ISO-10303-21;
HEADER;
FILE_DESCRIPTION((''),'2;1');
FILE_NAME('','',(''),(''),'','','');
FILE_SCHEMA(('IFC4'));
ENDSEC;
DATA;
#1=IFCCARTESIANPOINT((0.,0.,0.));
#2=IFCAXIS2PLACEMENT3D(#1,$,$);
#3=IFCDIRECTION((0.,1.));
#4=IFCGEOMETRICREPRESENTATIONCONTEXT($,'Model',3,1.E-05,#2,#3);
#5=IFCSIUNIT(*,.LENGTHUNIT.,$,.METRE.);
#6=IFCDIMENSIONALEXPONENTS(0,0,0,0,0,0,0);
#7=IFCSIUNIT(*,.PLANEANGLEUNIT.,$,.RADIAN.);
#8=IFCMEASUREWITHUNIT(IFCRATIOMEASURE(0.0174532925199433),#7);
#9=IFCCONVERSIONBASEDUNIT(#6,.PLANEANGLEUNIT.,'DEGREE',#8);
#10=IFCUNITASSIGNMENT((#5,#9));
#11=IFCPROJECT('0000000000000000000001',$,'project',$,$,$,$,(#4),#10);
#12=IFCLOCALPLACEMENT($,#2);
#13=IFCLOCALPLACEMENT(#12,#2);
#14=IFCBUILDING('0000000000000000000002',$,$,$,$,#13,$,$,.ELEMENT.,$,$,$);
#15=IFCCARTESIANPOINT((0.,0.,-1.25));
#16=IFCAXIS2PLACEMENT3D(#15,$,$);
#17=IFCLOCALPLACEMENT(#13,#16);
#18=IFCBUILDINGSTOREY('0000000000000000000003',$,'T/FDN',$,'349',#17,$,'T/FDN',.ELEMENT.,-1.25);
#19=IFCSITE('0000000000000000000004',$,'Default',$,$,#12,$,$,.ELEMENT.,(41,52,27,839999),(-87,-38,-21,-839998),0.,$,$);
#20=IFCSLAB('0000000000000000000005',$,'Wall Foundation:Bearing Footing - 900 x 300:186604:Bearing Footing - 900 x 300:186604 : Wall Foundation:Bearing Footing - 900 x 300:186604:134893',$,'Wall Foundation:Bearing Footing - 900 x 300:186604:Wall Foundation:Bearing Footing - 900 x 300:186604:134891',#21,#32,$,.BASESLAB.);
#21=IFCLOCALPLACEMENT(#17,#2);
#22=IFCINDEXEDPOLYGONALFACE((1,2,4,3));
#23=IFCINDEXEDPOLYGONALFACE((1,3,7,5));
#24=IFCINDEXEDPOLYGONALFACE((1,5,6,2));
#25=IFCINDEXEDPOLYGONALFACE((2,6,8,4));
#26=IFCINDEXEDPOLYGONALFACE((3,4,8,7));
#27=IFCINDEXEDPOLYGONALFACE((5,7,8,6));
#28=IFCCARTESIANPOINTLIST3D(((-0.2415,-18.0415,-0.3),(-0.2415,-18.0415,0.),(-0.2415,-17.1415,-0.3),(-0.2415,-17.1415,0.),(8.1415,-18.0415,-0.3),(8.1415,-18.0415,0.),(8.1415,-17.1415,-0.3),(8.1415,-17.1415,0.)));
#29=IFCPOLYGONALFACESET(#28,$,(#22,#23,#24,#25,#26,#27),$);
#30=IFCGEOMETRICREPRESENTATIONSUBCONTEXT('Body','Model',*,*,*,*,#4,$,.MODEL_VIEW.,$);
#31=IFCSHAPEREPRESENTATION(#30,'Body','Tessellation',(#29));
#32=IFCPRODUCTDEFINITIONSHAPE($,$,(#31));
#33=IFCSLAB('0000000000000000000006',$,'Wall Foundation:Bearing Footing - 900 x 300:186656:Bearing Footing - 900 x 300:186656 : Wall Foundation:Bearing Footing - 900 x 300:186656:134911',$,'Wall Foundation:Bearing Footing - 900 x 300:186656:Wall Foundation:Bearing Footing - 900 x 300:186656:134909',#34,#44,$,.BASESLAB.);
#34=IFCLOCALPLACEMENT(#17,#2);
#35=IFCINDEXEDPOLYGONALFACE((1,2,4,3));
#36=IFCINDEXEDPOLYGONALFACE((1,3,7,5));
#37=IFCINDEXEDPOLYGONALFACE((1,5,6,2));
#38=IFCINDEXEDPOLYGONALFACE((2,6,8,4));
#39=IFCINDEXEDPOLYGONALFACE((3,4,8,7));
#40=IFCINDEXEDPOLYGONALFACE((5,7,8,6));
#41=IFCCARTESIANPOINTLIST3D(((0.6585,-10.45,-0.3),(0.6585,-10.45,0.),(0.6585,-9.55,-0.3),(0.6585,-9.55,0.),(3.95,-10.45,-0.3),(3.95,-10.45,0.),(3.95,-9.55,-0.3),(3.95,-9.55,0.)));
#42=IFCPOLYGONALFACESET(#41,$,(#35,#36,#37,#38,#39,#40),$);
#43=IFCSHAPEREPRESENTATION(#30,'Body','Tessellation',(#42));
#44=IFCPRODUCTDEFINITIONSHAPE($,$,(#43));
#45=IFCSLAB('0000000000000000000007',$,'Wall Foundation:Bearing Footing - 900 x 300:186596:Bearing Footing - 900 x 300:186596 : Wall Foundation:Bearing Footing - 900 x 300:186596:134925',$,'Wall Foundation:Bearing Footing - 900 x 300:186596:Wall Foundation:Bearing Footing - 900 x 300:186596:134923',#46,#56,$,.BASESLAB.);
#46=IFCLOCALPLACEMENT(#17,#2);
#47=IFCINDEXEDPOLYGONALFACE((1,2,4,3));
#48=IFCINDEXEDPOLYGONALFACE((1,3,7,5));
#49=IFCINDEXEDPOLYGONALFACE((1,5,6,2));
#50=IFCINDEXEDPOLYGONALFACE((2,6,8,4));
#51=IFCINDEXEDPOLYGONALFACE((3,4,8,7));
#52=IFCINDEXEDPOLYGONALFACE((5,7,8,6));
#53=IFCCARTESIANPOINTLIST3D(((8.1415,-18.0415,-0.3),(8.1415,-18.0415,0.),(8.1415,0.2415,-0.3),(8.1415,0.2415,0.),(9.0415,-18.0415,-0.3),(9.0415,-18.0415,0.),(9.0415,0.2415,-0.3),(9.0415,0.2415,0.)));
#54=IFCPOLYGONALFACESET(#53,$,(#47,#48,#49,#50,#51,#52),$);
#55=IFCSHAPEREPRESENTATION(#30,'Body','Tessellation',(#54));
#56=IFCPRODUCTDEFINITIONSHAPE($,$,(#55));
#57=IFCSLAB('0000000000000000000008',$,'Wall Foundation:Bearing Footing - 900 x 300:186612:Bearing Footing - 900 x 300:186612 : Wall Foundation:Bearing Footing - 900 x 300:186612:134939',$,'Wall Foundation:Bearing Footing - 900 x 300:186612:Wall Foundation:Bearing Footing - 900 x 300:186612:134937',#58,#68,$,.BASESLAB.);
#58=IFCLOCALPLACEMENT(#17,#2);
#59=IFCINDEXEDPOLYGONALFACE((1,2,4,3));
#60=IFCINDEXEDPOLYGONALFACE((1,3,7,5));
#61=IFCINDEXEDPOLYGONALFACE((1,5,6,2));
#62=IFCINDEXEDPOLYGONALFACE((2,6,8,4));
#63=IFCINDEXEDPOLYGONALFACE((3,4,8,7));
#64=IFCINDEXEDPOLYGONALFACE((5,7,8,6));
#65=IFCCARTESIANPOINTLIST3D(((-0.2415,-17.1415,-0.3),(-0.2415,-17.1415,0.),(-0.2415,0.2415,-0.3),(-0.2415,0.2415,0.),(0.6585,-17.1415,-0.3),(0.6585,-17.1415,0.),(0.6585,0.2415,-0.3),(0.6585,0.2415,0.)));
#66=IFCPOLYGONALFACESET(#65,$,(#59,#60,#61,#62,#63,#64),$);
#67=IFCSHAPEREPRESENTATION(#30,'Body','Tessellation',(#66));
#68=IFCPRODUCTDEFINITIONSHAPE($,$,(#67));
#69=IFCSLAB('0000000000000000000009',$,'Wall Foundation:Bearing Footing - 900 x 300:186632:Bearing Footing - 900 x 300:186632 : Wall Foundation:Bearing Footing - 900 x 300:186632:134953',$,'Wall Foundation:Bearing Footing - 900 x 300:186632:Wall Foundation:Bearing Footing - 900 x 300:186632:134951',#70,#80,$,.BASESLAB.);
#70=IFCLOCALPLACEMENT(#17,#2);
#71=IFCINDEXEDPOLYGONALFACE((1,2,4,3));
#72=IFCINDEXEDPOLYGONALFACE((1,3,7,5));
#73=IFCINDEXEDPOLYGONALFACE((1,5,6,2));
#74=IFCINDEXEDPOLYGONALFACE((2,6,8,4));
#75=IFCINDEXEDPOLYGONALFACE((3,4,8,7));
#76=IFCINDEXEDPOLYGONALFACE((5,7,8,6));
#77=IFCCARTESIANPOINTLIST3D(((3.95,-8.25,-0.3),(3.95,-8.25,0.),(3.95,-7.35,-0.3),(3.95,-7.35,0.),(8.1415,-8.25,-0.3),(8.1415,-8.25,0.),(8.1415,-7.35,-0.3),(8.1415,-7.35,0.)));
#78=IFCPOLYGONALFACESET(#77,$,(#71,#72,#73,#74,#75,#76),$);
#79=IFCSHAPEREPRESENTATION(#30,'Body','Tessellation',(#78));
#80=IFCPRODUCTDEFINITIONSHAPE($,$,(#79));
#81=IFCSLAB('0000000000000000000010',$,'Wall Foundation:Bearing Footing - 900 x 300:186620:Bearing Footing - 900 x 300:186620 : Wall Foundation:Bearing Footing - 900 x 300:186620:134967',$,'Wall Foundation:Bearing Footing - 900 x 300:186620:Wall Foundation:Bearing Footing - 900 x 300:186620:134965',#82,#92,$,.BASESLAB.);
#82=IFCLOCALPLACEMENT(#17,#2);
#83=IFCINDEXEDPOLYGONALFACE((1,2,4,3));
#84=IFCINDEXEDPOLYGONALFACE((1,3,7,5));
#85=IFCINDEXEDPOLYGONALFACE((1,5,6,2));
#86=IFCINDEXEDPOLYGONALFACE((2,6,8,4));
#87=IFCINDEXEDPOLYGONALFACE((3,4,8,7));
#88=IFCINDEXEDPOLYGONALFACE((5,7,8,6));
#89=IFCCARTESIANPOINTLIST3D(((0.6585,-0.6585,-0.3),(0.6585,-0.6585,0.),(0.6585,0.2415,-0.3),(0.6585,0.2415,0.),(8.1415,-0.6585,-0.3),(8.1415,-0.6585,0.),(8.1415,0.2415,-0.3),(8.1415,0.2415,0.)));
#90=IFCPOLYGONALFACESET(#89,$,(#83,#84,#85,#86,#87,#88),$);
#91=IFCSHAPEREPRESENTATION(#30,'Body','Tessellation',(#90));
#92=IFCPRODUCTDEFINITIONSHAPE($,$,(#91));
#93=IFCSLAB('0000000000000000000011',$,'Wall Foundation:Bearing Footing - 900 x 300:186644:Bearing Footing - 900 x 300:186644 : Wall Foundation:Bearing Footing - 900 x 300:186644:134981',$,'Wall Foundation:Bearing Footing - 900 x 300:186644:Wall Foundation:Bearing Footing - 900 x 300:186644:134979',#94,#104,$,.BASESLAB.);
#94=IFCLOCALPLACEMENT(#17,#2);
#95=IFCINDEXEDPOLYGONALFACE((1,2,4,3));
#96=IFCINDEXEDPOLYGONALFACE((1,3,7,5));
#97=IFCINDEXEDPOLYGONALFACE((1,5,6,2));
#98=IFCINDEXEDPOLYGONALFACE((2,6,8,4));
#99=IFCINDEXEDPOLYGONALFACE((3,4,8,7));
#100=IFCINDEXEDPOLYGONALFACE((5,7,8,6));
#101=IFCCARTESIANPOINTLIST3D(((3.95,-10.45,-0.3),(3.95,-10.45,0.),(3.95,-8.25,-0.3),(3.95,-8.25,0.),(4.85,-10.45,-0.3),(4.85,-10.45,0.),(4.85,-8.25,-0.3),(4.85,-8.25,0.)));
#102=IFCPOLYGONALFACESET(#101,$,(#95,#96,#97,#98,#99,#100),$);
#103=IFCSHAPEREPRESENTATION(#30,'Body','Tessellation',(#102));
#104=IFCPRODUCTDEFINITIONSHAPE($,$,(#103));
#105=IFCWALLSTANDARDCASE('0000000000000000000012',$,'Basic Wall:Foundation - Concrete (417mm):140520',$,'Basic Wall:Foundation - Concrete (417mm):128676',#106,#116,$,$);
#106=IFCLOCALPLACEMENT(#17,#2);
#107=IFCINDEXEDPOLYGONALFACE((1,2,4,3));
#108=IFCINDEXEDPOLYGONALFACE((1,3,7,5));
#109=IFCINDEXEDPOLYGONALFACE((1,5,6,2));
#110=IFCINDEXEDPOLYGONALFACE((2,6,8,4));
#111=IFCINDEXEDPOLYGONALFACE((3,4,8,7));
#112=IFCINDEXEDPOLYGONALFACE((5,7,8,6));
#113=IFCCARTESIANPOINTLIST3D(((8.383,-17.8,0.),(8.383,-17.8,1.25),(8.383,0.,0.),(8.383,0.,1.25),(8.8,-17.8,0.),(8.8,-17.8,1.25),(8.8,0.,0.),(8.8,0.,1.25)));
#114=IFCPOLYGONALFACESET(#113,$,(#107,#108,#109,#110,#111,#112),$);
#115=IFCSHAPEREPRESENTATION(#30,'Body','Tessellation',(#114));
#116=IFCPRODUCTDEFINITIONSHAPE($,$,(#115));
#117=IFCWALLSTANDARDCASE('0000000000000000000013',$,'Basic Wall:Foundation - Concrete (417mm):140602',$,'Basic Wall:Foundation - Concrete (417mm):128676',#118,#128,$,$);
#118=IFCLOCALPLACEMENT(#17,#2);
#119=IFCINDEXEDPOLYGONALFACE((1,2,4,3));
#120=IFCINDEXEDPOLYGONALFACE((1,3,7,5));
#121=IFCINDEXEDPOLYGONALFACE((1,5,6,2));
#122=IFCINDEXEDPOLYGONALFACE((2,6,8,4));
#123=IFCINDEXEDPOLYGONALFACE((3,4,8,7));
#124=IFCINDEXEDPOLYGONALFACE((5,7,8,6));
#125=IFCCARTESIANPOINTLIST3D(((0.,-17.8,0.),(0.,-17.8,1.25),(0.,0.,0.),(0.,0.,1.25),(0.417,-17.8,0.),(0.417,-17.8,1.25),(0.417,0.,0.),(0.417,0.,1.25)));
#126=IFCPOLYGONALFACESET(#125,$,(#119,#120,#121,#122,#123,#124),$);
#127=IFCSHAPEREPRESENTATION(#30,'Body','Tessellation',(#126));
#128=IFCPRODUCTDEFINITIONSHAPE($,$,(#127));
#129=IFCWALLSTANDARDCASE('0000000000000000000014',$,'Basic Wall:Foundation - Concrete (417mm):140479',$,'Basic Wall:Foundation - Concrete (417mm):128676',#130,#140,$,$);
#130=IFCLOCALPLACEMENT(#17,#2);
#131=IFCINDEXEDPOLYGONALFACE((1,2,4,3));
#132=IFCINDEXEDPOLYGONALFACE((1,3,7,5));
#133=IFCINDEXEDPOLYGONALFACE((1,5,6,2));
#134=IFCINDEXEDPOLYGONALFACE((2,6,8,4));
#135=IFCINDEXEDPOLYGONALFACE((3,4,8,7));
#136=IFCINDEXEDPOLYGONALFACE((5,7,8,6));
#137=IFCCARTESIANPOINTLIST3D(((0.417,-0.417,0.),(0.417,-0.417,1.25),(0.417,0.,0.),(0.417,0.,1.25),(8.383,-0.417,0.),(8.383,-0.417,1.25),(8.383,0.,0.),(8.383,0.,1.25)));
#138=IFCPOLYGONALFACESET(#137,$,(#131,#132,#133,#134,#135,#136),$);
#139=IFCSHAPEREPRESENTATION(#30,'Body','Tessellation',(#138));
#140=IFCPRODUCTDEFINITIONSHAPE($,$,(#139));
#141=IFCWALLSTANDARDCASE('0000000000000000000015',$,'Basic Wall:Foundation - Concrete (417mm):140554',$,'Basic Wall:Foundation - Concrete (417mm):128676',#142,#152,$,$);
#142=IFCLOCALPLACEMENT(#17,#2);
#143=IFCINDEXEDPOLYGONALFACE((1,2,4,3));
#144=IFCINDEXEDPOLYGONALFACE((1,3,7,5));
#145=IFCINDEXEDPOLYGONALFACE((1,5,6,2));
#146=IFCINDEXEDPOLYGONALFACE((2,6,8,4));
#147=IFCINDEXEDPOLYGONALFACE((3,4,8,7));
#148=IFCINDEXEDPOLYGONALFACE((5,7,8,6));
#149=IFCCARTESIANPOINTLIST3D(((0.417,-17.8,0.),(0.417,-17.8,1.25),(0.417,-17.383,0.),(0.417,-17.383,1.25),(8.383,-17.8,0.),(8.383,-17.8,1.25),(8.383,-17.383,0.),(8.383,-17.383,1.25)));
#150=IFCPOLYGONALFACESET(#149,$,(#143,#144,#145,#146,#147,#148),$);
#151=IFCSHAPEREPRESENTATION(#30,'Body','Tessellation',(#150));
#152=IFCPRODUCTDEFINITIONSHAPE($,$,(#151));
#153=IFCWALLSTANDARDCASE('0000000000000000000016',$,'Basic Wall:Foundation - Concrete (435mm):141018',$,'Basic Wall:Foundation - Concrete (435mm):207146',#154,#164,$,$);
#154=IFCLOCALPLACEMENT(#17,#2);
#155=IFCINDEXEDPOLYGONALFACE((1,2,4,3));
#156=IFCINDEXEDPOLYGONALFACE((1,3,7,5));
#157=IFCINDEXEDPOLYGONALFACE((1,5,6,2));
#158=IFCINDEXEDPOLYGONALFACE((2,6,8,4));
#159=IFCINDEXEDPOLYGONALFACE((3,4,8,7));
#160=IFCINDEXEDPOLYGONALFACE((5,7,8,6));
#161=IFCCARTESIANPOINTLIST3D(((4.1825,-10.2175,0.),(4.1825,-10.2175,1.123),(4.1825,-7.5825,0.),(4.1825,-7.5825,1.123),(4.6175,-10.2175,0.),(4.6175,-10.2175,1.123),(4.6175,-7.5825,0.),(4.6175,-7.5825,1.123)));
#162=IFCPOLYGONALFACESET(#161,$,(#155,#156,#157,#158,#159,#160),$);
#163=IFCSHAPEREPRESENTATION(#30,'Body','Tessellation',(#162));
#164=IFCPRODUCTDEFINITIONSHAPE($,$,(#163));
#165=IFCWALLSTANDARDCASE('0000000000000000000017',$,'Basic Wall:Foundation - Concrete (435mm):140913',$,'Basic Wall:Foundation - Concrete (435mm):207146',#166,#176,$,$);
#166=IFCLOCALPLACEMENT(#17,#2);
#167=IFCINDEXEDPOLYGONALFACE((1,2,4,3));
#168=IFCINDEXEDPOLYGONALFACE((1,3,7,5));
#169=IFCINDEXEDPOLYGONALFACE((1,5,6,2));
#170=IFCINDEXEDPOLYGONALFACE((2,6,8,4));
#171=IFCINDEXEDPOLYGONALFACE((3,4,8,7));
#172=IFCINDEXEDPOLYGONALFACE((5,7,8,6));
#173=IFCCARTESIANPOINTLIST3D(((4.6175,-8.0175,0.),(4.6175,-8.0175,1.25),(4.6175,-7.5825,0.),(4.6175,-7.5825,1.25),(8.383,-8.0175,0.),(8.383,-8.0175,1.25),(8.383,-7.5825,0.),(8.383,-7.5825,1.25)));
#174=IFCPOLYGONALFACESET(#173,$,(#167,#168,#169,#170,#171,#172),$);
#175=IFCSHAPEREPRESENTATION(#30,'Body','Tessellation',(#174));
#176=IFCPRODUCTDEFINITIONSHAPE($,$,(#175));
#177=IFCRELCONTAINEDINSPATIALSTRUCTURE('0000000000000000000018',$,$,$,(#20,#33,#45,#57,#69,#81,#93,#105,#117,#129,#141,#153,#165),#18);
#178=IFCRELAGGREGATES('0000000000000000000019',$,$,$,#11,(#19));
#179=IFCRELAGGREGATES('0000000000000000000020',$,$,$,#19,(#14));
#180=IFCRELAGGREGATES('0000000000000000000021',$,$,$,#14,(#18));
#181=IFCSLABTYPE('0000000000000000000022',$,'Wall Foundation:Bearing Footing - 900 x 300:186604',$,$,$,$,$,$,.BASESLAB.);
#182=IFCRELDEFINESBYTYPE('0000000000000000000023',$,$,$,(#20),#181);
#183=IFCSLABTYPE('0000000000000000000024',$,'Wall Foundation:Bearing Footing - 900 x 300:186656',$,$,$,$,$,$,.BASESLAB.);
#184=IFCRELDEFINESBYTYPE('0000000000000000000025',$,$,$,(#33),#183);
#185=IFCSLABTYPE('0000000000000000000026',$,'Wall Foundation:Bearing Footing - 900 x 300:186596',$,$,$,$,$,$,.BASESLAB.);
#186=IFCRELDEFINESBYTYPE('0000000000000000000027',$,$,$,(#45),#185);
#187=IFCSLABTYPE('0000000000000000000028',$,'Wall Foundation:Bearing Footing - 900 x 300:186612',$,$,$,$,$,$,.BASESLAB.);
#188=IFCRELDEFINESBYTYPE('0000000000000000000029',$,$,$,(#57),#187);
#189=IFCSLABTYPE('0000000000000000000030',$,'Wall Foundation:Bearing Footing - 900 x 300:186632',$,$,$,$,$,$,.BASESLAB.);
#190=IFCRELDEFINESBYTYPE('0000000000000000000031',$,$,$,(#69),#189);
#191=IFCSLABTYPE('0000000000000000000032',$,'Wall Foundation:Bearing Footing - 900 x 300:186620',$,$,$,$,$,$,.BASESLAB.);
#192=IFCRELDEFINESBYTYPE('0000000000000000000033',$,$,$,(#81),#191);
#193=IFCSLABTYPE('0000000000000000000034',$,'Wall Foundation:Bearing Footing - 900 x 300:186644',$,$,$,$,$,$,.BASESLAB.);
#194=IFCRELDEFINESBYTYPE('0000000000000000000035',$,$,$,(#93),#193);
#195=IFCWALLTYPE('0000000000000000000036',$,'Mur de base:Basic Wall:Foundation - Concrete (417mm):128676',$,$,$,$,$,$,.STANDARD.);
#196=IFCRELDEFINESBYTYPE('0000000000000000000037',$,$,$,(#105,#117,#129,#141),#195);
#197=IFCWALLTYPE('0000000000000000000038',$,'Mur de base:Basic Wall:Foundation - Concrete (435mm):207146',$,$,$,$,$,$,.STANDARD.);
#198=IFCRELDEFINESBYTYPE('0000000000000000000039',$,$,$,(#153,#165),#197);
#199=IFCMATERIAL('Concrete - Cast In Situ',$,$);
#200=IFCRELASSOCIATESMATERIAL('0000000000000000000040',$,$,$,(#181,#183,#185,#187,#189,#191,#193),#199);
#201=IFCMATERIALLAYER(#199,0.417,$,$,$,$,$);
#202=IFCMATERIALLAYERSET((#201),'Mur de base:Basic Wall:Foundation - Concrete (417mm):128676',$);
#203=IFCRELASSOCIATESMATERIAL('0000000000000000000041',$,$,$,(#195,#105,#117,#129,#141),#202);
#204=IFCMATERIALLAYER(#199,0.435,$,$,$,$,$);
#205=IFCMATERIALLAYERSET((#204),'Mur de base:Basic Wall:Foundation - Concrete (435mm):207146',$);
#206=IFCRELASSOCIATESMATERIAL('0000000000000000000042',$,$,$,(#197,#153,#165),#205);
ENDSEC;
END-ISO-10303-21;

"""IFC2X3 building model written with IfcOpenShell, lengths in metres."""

from ifc_helpers import new_model, entity, si_unit, converted_unit, direction, frame, frame_2d, origin, origin_2d_with_axis, place, context, subcontext, project, spatial, rectangle, extrude, material, layer, layer_set, layer_usage, type_object, element, save


model = new_model("IFC2X3")

# Units and contexts
model_context = context("Model", 3, precision=1e-05, world=origin(), true_north=direction((0.0, 1.0)))
body_context = subcontext(model_context, "Body", "Model", "MODEL_VIEW")
ifc_project = project(units=[si_unit("LENGTHUNIT", "METRE"), converted_unit("PLANEANGLEUNIT", "DEGREE", entity("IfcRatioMeasure", 0.0174532925199433), si_unit("PLANEANGLEUNIT", "RADIAN"), dimensions=[0, 0, 0, 0, 0, 0, 0])], contexts=[model_context])

# Site, building, storey
site_placement = place(None, origin())
site = spatial("IfcSite", under=ifc_project, at=site_placement, Name="Default", CompositionType="ELEMENT", RefLatitude=(41, 52, 27, 839999), RefLongitude=(-87, -38, -21, -839998), RefElevation=0.0)
building_placement = place(site_placement, origin())
building = spatial("IfcBuilding", under=site, at=building_placement, CompositionType="ELEMENT")
storey_placement = place(building_placement, frame((0.0, 0.0, -1.25)))
storey = spatial("IfcBuildingStorey", under=building, at=storey_placement, Name="T/FDN", ObjectType="349", LongName="T/FDN", CompositionType="ELEMENT", Elevation=-1.25)

# Slabs
ifc_material = material(Name="Concrete - Cast In Situ")
slab_type_1 = type_object("IfcSlabType", Name="Wall Foundation:Bearing Footing - 900 x 300:186604", PredefinedType="BASESLAB", material=ifc_material)
slab_1_placement = place(storey_placement, origin())
element("IfcSlab", 1, at=slab_1_placement, inside=storey, type_object=slab_type_1, Name="Wall Foundation:Bearing Footing - 900 x 300:186604:Bearing Footing - 900 x 300:186604 : Wall Foundation:Bearing Footing - 900 x 300:186604:134893", ObjectType="Wall Foundation:Bearing Footing - 900 x 300:186604:Wall Foundation:Bearing Footing - 900 x 300:186604:134891", PredefinedType="BASESLAB", context=body_context, shape_type="SweptSolid", body=[
    extrude(rectangle(XDim=0.9, YDim=8.383, at=origin_2d_with_axis()), frame((3.95, -17.5915, -0.3), z_axis=(0.0, 0.0, 1.0), x_axis=(0.0, 1.0, 0.0)), (0.0, 0.0, 1.0), 0.3),
])
slab_type_2 = type_object("IfcSlabType", Name="Wall Foundation:Bearing Footing - 900 x 300:186656", PredefinedType="BASESLAB", material=ifc_material)
slab_2_placement = place(storey_placement, origin())
element("IfcSlab", 2, at=slab_2_placement, inside=storey, type_object=slab_type_2, Name="Wall Foundation:Bearing Footing - 900 x 300:186656:Bearing Footing - 900 x 300:186656 : Wall Foundation:Bearing Footing - 900 x 300:186656:134911", ObjectType="Wall Foundation:Bearing Footing - 900 x 300:186656:Wall Foundation:Bearing Footing - 900 x 300:186656:134909", PredefinedType="BASESLAB", context=body_context, shape_type="SweptSolid", body=[
    extrude(rectangle(XDim=0.9, YDim=3.2915, at=frame_2d((0.0, 0.0), x_axis=(1.0, 0.0))), frame((2.3043, -10.0, -0.3), z_axis=(0.0, 0.0, 1.0), x_axis=(0.0, 1.0, 0.0)), (0.0, 0.0, 1.0), 0.3),
])
slab_type_3 = type_object("IfcSlabType", Name="Wall Foundation:Bearing Footing - 900 x 300:186596", PredefinedType="BASESLAB", material=ifc_material)
slab_3_placement = place(storey_placement, origin())
element("IfcSlab", 3, at=slab_3_placement, inside=storey, type_object=slab_type_3, Name="Wall Foundation:Bearing Footing - 900 x 300:186596:Bearing Footing - 900 x 300:186596 : Wall Foundation:Bearing Footing - 900 x 300:186596:134925", ObjectType="Wall Foundation:Bearing Footing - 900 x 300:186596:Wall Foundation:Bearing Footing - 900 x 300:186596:134923", PredefinedType="BASESLAB", context=body_context, shape_type="SweptSolid", body=[
    extrude(rectangle(XDim=0.9, YDim=18.283, at=frame_2d((0.0, 0.0), x_axis=(1.0, 0.0))), frame((8.5915, -8.9, -0.3)), (0.0, 0.0, 1.0), 0.3),
])
slab_type_4 = type_object("IfcSlabType", Name="Wall Foundation:Bearing Footing - 900 x 300:186612", PredefinedType="BASESLAB", material=ifc_material)
slab_4_placement = place(storey_placement, origin())
element("IfcSlab", 4, at=slab_4_placement, inside=storey, type_object=slab_type_4, Name="Wall Foundation:Bearing Footing - 900 x 300:186612:Bearing Footing - 900 x 300:186612 : Wall Foundation:Bearing Footing - 900 x 300:186612:134939", ObjectType="Wall Foundation:Bearing Footing - 900 x 300:186612:Wall Foundation:Bearing Footing - 900 x 300:186612:134937", PredefinedType="BASESLAB", context=body_context, shape_type="SweptSolid", body=[
    extrude(rectangle(XDim=0.9, YDim=17.383, at=origin_2d_with_axis()), frame((0.2085, -8.45, -0.3)), (0.0, 0.0, 1.0), 0.3),
])
slab_type_5 = type_object("IfcSlabType", Name="Wall Foundation:Bearing Footing - 900 x 300:186632", PredefinedType="BASESLAB", material=ifc_material)
slab_5_placement = place(storey_placement, origin())
element("IfcSlab", 5, at=slab_5_placement, inside=storey, type_object=slab_type_5, Name="Wall Foundation:Bearing Footing - 900 x 300:186632:Bearing Footing - 900 x 300:186632 : Wall Foundation:Bearing Footing - 900 x 300:186632:134953", ObjectType="Wall Foundation:Bearing Footing - 900 x 300:186632:Wall Foundation:Bearing Footing - 900 x 300:186632:134951", PredefinedType="BASESLAB", context=body_context, shape_type="SweptSolid", body=[
    extrude(rectangle(XDim=0.9, YDim=4.1915, at=frame_2d((0.0, 0.0), x_axis=(1.0, 0.0))), frame((6.0457, -7.8, -0.3), z_axis=(0.0, 0.0, 1.0), x_axis=(0.0, -1.0, 0.0)), (0.0, 0.0, 1.0), 0.3),
])
slab_type_6 = type_object("IfcSlabType", Name="Wall Foundation:Bearing Footing - 900 x 300:186620", PredefinedType="BASESLAB", material=ifc_material)
slab_6_placement = place(storey_placement, origin())
element("IfcSlab", 6, at=slab_6_placement, inside=storey, type_object=slab_type_6, Name="Wall Foundation:Bearing Footing - 900 x 300:186620:Bearing Footing - 900 x 300:186620 : Wall Foundation:Bearing Footing - 900 x 300:186620:134967", ObjectType="Wall Foundation:Bearing Footing - 900 x 300:186620:Wall Foundation:Bearing Footing - 900 x 300:186620:134965", PredefinedType="BASESLAB", context=body_context, shape_type="SweptSolid", body=[
    extrude(rectangle(XDim=0.9, YDim=7.483, at=frame_2d((0.0, 0.0), x_axis=(1.0, 0.0))), frame((4.4, -0.2085, -0.3), z_axis=(0.0, 0.0, 1.0), x_axis=(0.0, -1.0, 0.0)), (0.0, 0.0, 1.0), 0.3),
])
slab_type_7 = type_object("IfcSlabType", Name="Wall Foundation:Bearing Footing - 900 x 300:186644", PredefinedType="BASESLAB", material=ifc_material)
slab_7_placement = place(storey_placement, origin())
element("IfcSlab", 7, at=slab_7_placement, inside=storey, type_object=slab_type_7, Name="Wall Foundation:Bearing Footing - 900 x 300:186644:Bearing Footing - 900 x 300:186644 : Wall Foundation:Bearing Footing - 900 x 300:186644:134981", ObjectType="Wall Foundation:Bearing Footing - 900 x 300:186644:Wall Foundation:Bearing Footing - 900 x 300:186644:134979", PredefinedType="BASESLAB", context=body_context, shape_type="SweptSolid", body=[
    extrude(rectangle(XDim=0.9, YDim=2.2, at=frame_2d((0.0, 0.0), x_axis=(1.0, 0.0))), frame((4.4, -9.35, -0.3), z_axis=(0.0, 0.0, 1.0), x_axis=(-1.0, 0.0, 0.0)), (0.0, 0.0, 1.0), 0.3),
])

# Walls
ifc_layer_1 = layer(ifc_material, 0.417)
ifc_layer_set_1 = layer_set([ifc_layer_1], Name="Mur de base:Basic Wall:Foundation - Concrete (417mm):128676")
ifc_layer_usage_1 = layer_usage(ifc_layer_set_1, "AXIS2", "NEGATIVE", 0.2085)
wall_type_1 = type_object("IfcWallType", Name="Mur de base:Basic Wall:Foundation - Concrete (417mm):128676", PredefinedType="STANDARD", material=ifc_layer_set_1)
wall_1_placement = place(storey_placement, frame((8.5915, 0.0, 0.0), z_axis=(0.0, 0.0, 1.0), x_axis=(0.0, -1.0, 0.0)))
element("IfcWallStandardCase", 8, at=wall_1_placement, inside=storey, type_object=wall_type_1, material=ifc_layer_usage_1, Name="Basic Wall:Foundation - Concrete (417mm):140520", ObjectType="Basic Wall:Foundation - Concrete (417mm):128676", context=body_context, shape_type="SweptSolid", body=[
    extrude(rectangle(XDim=17.8, YDim=0.417, at=frame_2d((8.9, 0.0), x_axis=(-1.0, 0.0))), origin(), (0.0, 0.0, 1.0), 1.25),
])
ifc_layer_usage_2 = layer_usage(ifc_layer_set_1, "AXIS2", "NEGATIVE", 0.2085)
wall_2_placement = place(storey_placement, frame((0.2085, -17.8, 0.0), z_axis=(0.0, 0.0, 1.0), x_axis=(0.0, 1.0, 0.0)))
element("IfcWallStandardCase", 9, at=wall_2_placement, inside=storey, type_object=wall_type_1, material=ifc_layer_usage_2, Name="Basic Wall:Foundation - Concrete (417mm):140602", ObjectType="Basic Wall:Foundation - Concrete (417mm):128676", context=body_context, shape_type="SweptSolid", body=[
    extrude(rectangle(XDim=17.8, YDim=0.417, at=frame_2d((8.9, 0.0), x_axis=(-1.0, 0.0))), origin(), (0.0, 0.0, 1.0), 1.25),
])
ifc_layer_usage_3 = layer_usage(ifc_layer_set_1, "AXIS2", "NEGATIVE", 0.2085)
wall_3_placement = place(storey_placement, frame((0.417, -0.2085, 0.0)))
element("IfcWallStandardCase", 10, at=wall_3_placement, inside=storey, type_object=wall_type_1, material=ifc_layer_usage_3, Name="Basic Wall:Foundation - Concrete (417mm):140479", ObjectType="Basic Wall:Foundation - Concrete (417mm):128676", context=body_context, shape_type="SweptSolid", body=[
    extrude(rectangle(XDim=7.966, YDim=0.417, at=frame_2d((3.983, 0.0), x_axis=(-1.0, 0.0))), origin(), (0.0, 0.0, 1.0), 1.25),
])
ifc_layer_usage_4 = layer_usage(ifc_layer_set_1, "AXIS2", "NEGATIVE", 0.2085)
wall_4_placement = place(storey_placement, frame((8.383, -17.5915, 0.0), z_axis=(0.0, 0.0, 1.0), x_axis=(-1.0, 0.0, 0.0)))
element("IfcWallStandardCase", 11, at=wall_4_placement, inside=storey, type_object=wall_type_1, material=ifc_layer_usage_4, Name="Basic Wall:Foundation - Concrete (417mm):140554", ObjectType="Basic Wall:Foundation - Concrete (417mm):128676", context=body_context, shape_type="SweptSolid", body=[
    extrude(rectangle(XDim=7.966, YDim=0.417, at=frame_2d((3.983, 0.0), x_axis=(-1.0, 0.0))), origin(), (0.0, 0.0, 1.0), 1.25),
])
ifc_layer_2 = layer(ifc_material, 0.435)
ifc_layer_set_2 = layer_set([ifc_layer_2], Name="Mur de base:Basic Wall:Foundation - Concrete (435mm):207146")
ifc_layer_usage_5 = layer_usage(ifc_layer_set_2, "AXIS2", "NEGATIVE", 0.2175)
wall_type_2 = type_object("IfcWallType", Name="Mur de base:Basic Wall:Foundation - Concrete (435mm):207146", PredefinedType="STANDARD", material=ifc_layer_set_2)
wall_5_placement = place(storey_placement, frame((4.4, -10.2175, 0.0), z_axis=(0.0, 0.0, 1.0), x_axis=(0.0, 1.0, 0.0)))
element("IfcWallStandardCase", 12, at=wall_5_placement, inside=storey, type_object=wall_type_2, material=ifc_layer_usage_5, Name="Basic Wall:Foundation - Concrete (435mm):141018", ObjectType="Basic Wall:Foundation - Concrete (435mm):207146", context=body_context, shape_type="SweptSolid", body=[
    extrude(rectangle(XDim=2.635, YDim=0.435, at=frame_2d((1.3175, 0.0), x_axis=(-1.0, 0.0))), origin(), (0.0, 0.0, 1.0), 1.123),
])
ifc_layer_usage_6 = layer_usage(ifc_layer_set_2, "AXIS2", "NEGATIVE", 0.2175)
wall_6_placement = place(storey_placement, frame((8.383, -7.8, 0.0), z_axis=(0.0, 0.0, 1.0), x_axis=(-1.0, 0.0, 0.0)))
element("IfcWallStandardCase", 13, at=wall_6_placement, inside=storey, type_object=wall_type_2, material=ifc_layer_usage_6, Name="Basic Wall:Foundation - Concrete (435mm):140913", ObjectType="Basic Wall:Foundation - Concrete (435mm):207146", context=body_context, shape_type="SweptSolid", body=[
    extrude(rectangle(XDim=3.7655, YDim=0.435, at=frame_2d((1.8827, 0.0), x_axis=(-1.0, 0.0))), origin(), (0.0, 0.0, 1.0), 1.25),
])

save(model, "model.ifc")
